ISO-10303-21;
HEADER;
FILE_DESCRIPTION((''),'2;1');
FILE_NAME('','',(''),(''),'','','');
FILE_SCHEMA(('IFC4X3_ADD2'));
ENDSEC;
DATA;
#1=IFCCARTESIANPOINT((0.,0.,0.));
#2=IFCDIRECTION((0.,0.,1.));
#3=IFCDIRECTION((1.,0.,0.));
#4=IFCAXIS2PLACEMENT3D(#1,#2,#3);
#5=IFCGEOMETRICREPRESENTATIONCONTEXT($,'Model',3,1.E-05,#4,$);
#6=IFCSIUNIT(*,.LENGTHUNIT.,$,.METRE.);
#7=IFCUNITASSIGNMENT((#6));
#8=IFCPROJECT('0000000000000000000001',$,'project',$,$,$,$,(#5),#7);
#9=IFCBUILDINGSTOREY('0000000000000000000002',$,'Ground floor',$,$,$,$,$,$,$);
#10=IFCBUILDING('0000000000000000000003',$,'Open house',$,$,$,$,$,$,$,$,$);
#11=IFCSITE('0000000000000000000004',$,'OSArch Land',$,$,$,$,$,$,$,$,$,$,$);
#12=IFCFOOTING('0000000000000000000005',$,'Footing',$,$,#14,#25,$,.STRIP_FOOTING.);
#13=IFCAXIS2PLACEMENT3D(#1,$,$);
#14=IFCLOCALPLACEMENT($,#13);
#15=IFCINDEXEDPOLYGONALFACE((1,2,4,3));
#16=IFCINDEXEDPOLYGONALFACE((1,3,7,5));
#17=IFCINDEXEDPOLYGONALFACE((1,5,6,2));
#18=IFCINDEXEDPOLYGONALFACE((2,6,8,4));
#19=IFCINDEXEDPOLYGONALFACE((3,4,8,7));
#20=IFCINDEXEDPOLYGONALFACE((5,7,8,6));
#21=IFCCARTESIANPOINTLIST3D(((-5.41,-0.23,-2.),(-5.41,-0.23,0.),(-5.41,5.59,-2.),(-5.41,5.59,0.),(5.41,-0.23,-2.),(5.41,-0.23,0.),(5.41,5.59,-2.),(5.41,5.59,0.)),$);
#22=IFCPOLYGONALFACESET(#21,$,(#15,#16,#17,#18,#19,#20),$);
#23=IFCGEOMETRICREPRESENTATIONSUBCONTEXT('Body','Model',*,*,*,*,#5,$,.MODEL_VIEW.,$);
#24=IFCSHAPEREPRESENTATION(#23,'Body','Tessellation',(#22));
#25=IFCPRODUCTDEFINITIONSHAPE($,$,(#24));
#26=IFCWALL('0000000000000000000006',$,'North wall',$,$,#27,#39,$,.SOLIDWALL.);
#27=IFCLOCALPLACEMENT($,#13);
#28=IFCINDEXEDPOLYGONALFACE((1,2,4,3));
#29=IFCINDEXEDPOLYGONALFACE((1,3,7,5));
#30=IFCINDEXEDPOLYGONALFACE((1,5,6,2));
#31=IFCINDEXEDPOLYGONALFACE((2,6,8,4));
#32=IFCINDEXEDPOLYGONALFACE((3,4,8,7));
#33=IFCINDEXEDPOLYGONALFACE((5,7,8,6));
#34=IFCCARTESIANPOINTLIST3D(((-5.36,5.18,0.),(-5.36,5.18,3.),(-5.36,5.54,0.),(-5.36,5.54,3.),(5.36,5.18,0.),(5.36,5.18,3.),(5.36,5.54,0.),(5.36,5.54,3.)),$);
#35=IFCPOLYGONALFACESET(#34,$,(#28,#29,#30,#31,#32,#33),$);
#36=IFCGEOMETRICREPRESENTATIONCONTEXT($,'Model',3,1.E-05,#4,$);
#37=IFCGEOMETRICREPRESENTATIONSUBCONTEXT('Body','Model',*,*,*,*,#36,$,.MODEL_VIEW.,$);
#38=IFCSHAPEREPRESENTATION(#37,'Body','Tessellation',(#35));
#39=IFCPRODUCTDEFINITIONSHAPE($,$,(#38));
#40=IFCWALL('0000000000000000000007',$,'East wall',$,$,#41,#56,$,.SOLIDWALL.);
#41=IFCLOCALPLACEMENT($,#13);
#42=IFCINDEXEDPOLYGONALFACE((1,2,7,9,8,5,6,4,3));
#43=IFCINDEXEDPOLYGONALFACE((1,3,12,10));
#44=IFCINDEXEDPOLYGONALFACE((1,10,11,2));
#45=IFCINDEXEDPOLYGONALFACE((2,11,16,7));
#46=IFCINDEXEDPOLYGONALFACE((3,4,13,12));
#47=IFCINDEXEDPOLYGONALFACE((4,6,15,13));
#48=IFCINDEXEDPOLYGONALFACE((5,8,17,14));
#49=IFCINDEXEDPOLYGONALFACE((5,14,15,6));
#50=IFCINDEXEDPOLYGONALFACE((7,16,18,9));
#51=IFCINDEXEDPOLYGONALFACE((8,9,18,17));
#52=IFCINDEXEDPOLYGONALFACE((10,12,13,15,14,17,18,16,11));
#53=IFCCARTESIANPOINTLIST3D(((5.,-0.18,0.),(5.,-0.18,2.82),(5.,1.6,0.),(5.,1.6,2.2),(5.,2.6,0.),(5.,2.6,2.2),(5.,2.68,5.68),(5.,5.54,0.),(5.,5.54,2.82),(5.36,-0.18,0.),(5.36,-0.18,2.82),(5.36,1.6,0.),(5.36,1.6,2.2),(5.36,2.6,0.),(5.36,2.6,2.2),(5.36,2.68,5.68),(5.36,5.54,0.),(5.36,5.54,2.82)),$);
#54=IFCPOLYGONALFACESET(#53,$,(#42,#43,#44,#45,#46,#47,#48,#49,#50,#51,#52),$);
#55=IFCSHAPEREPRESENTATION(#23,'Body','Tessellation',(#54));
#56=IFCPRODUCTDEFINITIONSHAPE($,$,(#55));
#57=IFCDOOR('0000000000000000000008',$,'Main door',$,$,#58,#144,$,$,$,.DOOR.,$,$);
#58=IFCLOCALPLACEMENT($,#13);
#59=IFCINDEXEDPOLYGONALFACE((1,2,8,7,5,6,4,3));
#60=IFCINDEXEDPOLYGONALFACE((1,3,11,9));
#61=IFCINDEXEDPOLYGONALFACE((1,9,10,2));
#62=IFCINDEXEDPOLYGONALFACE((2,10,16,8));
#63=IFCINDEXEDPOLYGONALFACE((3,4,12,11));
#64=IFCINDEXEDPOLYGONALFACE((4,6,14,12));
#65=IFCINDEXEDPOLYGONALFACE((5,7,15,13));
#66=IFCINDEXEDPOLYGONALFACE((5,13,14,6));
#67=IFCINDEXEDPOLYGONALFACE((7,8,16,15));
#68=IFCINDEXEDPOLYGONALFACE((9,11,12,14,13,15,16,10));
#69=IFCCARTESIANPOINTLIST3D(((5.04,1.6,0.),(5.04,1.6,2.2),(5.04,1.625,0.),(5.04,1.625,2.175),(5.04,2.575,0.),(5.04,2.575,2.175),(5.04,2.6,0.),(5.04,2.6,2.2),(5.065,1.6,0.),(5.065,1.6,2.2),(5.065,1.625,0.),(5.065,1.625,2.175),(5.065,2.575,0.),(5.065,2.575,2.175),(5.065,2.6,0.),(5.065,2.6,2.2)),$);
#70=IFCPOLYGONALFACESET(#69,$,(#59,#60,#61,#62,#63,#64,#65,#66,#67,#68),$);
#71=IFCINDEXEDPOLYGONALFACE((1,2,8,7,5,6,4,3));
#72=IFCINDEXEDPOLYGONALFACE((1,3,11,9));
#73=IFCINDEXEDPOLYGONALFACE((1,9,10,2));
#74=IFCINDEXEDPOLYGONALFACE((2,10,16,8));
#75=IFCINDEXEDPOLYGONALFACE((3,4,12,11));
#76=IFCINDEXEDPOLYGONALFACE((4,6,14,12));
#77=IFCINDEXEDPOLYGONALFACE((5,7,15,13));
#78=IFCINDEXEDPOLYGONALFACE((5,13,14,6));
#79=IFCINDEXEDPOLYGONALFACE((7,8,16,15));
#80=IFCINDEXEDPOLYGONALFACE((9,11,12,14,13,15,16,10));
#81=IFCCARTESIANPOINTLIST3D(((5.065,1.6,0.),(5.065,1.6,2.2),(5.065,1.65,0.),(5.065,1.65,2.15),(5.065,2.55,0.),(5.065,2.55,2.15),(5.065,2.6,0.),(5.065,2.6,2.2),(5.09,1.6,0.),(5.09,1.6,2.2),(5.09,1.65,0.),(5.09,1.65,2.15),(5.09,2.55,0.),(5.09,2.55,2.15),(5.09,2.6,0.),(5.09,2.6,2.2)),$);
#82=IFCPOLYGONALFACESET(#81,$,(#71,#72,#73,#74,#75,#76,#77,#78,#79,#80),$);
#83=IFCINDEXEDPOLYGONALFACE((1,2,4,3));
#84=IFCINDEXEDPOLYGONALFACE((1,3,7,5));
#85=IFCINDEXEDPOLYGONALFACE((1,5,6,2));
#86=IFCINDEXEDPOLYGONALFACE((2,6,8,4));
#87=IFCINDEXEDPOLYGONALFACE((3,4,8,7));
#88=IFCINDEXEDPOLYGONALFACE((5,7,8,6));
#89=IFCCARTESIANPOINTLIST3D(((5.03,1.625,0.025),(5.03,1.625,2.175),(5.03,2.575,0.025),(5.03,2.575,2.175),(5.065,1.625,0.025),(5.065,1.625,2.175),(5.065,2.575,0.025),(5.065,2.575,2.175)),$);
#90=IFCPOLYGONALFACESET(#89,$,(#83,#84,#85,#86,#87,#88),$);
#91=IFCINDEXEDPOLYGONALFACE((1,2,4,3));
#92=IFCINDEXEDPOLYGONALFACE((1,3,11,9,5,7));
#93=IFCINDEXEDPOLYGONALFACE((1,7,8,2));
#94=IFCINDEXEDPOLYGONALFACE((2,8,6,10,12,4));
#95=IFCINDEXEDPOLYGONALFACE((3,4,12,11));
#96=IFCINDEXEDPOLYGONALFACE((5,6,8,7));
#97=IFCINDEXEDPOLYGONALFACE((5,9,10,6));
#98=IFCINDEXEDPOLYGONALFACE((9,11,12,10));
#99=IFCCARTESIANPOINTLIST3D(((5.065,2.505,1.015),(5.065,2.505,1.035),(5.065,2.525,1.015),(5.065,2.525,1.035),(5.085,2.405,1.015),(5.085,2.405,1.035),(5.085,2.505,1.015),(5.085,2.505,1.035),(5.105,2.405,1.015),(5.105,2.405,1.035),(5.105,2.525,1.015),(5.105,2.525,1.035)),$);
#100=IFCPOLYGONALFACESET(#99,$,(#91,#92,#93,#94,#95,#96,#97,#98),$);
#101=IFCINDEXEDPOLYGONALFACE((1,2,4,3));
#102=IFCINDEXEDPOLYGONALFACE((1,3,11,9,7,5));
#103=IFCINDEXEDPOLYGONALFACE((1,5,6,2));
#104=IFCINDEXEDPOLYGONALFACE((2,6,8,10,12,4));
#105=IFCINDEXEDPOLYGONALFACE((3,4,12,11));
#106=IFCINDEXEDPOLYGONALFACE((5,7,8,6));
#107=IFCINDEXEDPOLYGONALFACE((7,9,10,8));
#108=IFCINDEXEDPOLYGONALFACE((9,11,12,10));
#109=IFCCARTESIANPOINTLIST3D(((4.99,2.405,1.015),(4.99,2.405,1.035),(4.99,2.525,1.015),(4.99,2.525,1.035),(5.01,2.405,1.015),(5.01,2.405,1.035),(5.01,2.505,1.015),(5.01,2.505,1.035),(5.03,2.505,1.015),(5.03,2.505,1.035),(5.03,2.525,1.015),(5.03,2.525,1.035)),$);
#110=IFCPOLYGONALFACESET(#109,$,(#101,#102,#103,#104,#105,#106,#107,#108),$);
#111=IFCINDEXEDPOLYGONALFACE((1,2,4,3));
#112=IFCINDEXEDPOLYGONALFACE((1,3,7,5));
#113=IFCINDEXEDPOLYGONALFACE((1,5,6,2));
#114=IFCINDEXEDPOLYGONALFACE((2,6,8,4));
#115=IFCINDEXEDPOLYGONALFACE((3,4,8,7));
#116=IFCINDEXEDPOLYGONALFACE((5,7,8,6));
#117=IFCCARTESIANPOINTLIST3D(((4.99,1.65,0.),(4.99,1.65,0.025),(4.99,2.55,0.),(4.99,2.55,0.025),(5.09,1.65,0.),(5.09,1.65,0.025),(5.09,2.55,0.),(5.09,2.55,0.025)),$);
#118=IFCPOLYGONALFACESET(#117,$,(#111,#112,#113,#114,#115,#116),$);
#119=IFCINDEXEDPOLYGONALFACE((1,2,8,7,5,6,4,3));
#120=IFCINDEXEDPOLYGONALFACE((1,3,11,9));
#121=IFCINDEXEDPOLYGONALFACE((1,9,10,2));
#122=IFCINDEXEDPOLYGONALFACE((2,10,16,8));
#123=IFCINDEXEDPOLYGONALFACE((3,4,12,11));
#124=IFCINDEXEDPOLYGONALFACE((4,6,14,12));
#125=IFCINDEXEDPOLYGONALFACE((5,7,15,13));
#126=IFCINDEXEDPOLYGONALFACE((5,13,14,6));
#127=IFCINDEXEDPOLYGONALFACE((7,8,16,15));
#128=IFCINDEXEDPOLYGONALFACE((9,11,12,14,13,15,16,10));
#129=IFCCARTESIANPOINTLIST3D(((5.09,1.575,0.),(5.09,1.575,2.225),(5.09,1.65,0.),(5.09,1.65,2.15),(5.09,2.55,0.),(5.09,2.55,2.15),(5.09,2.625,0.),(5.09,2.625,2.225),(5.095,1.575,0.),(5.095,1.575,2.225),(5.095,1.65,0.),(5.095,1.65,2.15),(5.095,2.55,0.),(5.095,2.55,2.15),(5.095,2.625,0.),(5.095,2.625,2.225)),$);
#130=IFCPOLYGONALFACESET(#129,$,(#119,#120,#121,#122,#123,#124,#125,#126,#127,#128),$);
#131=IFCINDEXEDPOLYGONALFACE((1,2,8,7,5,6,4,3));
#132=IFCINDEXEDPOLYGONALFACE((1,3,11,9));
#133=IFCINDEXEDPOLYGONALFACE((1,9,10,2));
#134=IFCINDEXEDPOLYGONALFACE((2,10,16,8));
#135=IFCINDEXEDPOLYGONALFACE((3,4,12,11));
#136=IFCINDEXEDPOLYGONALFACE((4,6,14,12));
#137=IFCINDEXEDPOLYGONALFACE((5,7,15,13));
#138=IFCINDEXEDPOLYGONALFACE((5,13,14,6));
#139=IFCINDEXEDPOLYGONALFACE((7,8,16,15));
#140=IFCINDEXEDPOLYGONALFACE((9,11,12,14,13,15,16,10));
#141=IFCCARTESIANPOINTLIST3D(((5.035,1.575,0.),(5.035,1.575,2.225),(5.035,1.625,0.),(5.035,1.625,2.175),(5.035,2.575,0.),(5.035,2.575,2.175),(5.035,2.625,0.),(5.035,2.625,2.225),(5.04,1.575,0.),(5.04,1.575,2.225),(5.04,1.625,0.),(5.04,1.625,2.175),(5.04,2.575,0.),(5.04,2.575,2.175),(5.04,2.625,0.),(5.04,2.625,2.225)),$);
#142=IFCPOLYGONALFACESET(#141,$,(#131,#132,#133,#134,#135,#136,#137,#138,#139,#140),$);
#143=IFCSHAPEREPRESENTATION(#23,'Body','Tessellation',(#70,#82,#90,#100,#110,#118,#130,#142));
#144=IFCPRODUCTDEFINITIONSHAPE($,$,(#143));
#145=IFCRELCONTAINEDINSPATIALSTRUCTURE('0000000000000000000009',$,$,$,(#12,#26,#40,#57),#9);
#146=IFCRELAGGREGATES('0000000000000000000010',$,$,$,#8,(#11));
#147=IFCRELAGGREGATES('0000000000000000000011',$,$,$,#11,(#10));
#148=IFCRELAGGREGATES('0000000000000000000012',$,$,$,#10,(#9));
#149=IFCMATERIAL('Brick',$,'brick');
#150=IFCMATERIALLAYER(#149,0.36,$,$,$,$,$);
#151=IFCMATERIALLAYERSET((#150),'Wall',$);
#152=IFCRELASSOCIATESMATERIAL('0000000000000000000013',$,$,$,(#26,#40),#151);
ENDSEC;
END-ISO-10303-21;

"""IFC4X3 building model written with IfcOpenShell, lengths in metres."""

from ifc_helpers import new_model, si_unit, frame, origin_with_axes, place, context, subcontext, project, spatial, line, indexed_curve, outline, extrude, clip, halfspace, material, layer, layer_set, layer_usage, element, fill, save


model = new_model("IFC4X3")

# Units and contexts
model_context_1 = context("Model", 3, precision=1e-05, world=origin_with_axes())
model_context_2 = context("Model", 3, precision=1e-05, world=origin_with_axes())
body_context_1 = subcontext(model_context_1, "Body", "Model", "MODEL_VIEW")
body_context_2 = subcontext(model_context_2, "Body", "Model", "MODEL_VIEW")
ifc_project = project(units=[si_unit("LENGTHUNIT", "METRE")], contexts=[model_context_1])

# Site, building, storey
site = spatial("IfcSite", under=ifc_project, Name="OSArch Land")
building = spatial("IfcBuilding", under=site, Name="Open house")
storey = spatial("IfcBuildingStorey", under=building, Name="Ground floor")

# Footing
footing_placement = place(None, frame((-5.41, -0.23, -2.0), z_axis=(0.0, 0.0, 1.0), x_axis=(1.0, 0.0, 0.0)))
element("IfcFooting", 1, at=footing_placement, inside=storey, Name="Footing", PredefinedType="STRIP_FOOTING", context=body_context_1, shape_type="SweptSolid", body=[
    extrude(outline(indexed_curve([(0.0, 0.0), (0.0, 5.82), (10.82, 5.82), (10.82, 0.0), (0.0, 0.0)], self_intersect=False)), origin_with_axes(), (0.0, 0.0, 1.0), 2.0),
])

# Shared definitions
ifc_material = material(Name="Brick", Category="brick")
ifc_layer = layer(ifc_material, 0.36)
ifc_layer_set = layer_set([ifc_layer], Name="Wall")

# Wall
ifc_layer_usage_1 = layer_usage(ifc_layer_set, "AXIS2", "POSITIVE", 0.0)
wall_1_placement = place(None, frame((-5.36, 5.18, 0.0), z_axis=(0.0, 0.0, 1.0), x_axis=(1.0, 0.0, 0.0)))
element("IfcWall", 2, at=wall_1_placement, inside=storey, material=ifc_layer_usage_1, Name="North wall", PredefinedType="SOLIDWALL", context=body_context_2, shape_type="SweptSolid", body=[
    extrude(outline(indexed_curve([(0.0, 0.0), (0.0, 0.36), (10.72, 0.36), (10.72, 0.0), (0.0, 0.0)], self_intersect=False)), origin_with_axes(), (0.0, 0.0, 1.0), 3.0),
])

# Wall, opening, door
ifc_layer_usage_2 = layer_usage(ifc_layer_set, "AXIS2", "POSITIVE", 0.0)
wall_2_placement = place(None, frame((5.0, -0.18, 0.0), z_axis=(0.0, 0.0, 1.0), x_axis=(1.0, 0.0, 0.0)))
wall_2 = element("IfcWall", 3, at=wall_2_placement, inside=storey, material=ifc_layer_usage_2, Name="East wall", PredefinedType="SOLIDWALL", context=body_context_1, shape_type="Clipping", body=[
    clip(clip(extrude(outline(indexed_curve([(0.0, 0.0), (0.0, 5.72), (0.36, 5.72), (0.36, 0.0), (0.0, 0.0)], self_intersect=False)), origin_with_axes(), (0.0, 0.0, 1.0), 6.08), halfspace(frame((0.0, 5.54, 3.0), z_axis=(0.0, 0.707107, 0.707107), x_axis=(1.0, 0.0, 0.0)), False)), halfspace(frame((0.0, 0.18, 3.0), z_axis=(0.0, -0.707107, 0.707107), x_axis=(1.0, 0.0, 0.0)), False)),
])
opening_1_placement = place(wall_2_placement, frame((-0.5, 1.78, 0.0), z_axis=(0.0, 0.0, 1.0), x_axis=(1.0, 0.0, 0.0)))
opening_1 = element("IfcOpeningElement", 4, at=opening_1_placement, cuts=wall_2, context=body_context_1, shape_type="SweptSolid", body=[
    extrude(outline(indexed_curve([(0.0, 0.0), (0.0, 1.0), (1.0, 1.0), (1.0, 0.0), (0.0, 0.0)], self_intersect=False)), origin_with_axes(), (0.0, 0.0, 1.0), 2.2),
])
door_placement = place(None, frame((5.09, 1.6, 0.0), z_axis=(0.0, 0.0, 1.0), x_axis=(0.0, 1.0, 0.0)))
door = element("IfcDoor", 5, at=door_placement, inside=storey, Name="Main door", PredefinedType="DOOR", context=body_context_1, shape_type="SweptSolid", body=[
    extrude(outline(indexed_curve([(0.0, 0.0, 0.0), (0.0, 0.0, 2.2), (1.0, 0.0, 2.2), (1.0, 0.0, 0.0), (0.975, 0.0, 0.0), (0.975, 0.0, 2.175), (0.025, 0.0, 2.175), (0.025, 0.0, 0.0)], segments=[line(1, 2), line(2, 3), line(3, 4), line(4, 5), line(5, 6), line(6, 7), line(7, 8), line(8, 1)])), frame((0.0, 0.025, 0.0), z_axis=(0.0, 0.0, 1.0), x_axis=(1.0, 0.0, 0.0)), (0.0, 1.0, 0.0), 0.025),
    extrude(outline(indexed_curve([(0.0, 0.0, 0.0), (0.0, 0.0, 2.2), (1.0, 0.0, 2.2), (1.0, 0.0, 0.0), (0.95, 0.0, 0.0), (0.95, 0.0, 2.15), (0.05, 0.0, 2.15), (0.05, 0.0, 0.0)], segments=[line(1, 2), line(2, 3), line(3, 4), line(4, 5), line(5, 6), line(6, 7), line(7, 8), line(8, 1)])), origin_with_axes(), (0.0, 1.0, 0.0), 0.025),
    extrude(outline(indexed_curve([(0.0, 0.0), (0.95, 0.0), (0.95, 0.035), (0.0, 0.035)], segments=[line(1, 2), line(2, 3), line(3, 4), line(4, 1)])), frame((0.025, 0.025, 0.025), z_axis=(0.0, 0.0, 1.0), x_axis=(1.0, 0.0, 0.0)), (0.0, 0.0, 1.0), 2.15),
    extrude(outline(indexed_curve([(0.0, 0.0), (0.0, -0.04), (-0.12, -0.04), (-0.12, -0.02), (-0.02, -0.02), (-0.02, 0.0)], segments=[line(1, 2), line(2, 3), line(3, 4), line(4, 5), line(5, 6), line(6, 1)])), frame((0.925, 0.025, 1.015), z_axis=(0.0, 0.0, 1.0), x_axis=(1.0, 0.0, 0.0)), (0.0, 0.0, 1.0), 0.02),
    extrude(outline(indexed_curve([(0.0, 0.0), (0.0, 0.04), (-0.12, 0.04), (-0.12, 0.02), (-0.02, 0.02), (-0.02, 0.0)], segments=[line(1, 2), line(2, 3), line(3, 4), line(4, 5), line(5, 6), line(6, 1)])), frame((0.925, 0.06, 1.015), z_axis=(0.0, 0.0, 1.0), x_axis=(1.0, 0.0, 0.0)), (0.0, 0.0, 1.0), 0.02),
    extrude(outline(indexed_curve([(0.0, 0.0), (0.9, 0.0), (0.9, 0.1), (0.0, 0.1)], segments=[line(1, 2), line(2, 3), line(3, 4), line(4, 1)])), frame((0.05, 0.0, 0.0), z_axis=(0.0, 0.0, 1.0), x_axis=(1.0, 0.0, 0.0)), (0.0, 0.0, 1.0), 0.025),
    extrude(outline(indexed_curve([(0.0, 0.0, 0.0), (0.0, 0.0, 2.225), (1.05, 0.0, 2.225), (1.05, 0.0, 0.0), (0.975, 0.0, 0.0), (0.975, 0.0, 2.15), (0.075, 0.0, 2.15), (0.075, 0.0, 0.0)], segments=[line(1, 2), line(2, 3), line(3, 4), line(4, 5), line(5, 6), line(6, 7), line(7, 8), line(8, 1)])), frame((-0.025, -0.005, 0.0), z_axis=(0.0, 0.0, 1.0), x_axis=(1.0, 0.0, 0.0)), (0.0, 1.0, 0.0), 0.005),
    extrude(outline(indexed_curve([(0.0, 0.0, 0.0), (0.0, 0.0, 2.225), (1.05, 0.0, 2.225), (1.05, 0.0, 0.0), (1.0, 0.0, 0.0), (1.0, 0.0, 2.175), (0.05, 0.0, 2.175), (0.05, 0.0, 0.0)], segments=[line(1, 2), line(2, 3), line(3, 4), line(4, 5), line(5, 6), line(6, 7), line(7, 8), line(8, 1)])), frame((-0.025, 0.05, 0.0), z_axis=(0.0, 0.0, 1.0), x_axis=(1.0, 0.0, 0.0)), (0.0, 1.0, 0.0), 0.005),
])
fill(opening_1, door)

save(model, "model.ifc")
